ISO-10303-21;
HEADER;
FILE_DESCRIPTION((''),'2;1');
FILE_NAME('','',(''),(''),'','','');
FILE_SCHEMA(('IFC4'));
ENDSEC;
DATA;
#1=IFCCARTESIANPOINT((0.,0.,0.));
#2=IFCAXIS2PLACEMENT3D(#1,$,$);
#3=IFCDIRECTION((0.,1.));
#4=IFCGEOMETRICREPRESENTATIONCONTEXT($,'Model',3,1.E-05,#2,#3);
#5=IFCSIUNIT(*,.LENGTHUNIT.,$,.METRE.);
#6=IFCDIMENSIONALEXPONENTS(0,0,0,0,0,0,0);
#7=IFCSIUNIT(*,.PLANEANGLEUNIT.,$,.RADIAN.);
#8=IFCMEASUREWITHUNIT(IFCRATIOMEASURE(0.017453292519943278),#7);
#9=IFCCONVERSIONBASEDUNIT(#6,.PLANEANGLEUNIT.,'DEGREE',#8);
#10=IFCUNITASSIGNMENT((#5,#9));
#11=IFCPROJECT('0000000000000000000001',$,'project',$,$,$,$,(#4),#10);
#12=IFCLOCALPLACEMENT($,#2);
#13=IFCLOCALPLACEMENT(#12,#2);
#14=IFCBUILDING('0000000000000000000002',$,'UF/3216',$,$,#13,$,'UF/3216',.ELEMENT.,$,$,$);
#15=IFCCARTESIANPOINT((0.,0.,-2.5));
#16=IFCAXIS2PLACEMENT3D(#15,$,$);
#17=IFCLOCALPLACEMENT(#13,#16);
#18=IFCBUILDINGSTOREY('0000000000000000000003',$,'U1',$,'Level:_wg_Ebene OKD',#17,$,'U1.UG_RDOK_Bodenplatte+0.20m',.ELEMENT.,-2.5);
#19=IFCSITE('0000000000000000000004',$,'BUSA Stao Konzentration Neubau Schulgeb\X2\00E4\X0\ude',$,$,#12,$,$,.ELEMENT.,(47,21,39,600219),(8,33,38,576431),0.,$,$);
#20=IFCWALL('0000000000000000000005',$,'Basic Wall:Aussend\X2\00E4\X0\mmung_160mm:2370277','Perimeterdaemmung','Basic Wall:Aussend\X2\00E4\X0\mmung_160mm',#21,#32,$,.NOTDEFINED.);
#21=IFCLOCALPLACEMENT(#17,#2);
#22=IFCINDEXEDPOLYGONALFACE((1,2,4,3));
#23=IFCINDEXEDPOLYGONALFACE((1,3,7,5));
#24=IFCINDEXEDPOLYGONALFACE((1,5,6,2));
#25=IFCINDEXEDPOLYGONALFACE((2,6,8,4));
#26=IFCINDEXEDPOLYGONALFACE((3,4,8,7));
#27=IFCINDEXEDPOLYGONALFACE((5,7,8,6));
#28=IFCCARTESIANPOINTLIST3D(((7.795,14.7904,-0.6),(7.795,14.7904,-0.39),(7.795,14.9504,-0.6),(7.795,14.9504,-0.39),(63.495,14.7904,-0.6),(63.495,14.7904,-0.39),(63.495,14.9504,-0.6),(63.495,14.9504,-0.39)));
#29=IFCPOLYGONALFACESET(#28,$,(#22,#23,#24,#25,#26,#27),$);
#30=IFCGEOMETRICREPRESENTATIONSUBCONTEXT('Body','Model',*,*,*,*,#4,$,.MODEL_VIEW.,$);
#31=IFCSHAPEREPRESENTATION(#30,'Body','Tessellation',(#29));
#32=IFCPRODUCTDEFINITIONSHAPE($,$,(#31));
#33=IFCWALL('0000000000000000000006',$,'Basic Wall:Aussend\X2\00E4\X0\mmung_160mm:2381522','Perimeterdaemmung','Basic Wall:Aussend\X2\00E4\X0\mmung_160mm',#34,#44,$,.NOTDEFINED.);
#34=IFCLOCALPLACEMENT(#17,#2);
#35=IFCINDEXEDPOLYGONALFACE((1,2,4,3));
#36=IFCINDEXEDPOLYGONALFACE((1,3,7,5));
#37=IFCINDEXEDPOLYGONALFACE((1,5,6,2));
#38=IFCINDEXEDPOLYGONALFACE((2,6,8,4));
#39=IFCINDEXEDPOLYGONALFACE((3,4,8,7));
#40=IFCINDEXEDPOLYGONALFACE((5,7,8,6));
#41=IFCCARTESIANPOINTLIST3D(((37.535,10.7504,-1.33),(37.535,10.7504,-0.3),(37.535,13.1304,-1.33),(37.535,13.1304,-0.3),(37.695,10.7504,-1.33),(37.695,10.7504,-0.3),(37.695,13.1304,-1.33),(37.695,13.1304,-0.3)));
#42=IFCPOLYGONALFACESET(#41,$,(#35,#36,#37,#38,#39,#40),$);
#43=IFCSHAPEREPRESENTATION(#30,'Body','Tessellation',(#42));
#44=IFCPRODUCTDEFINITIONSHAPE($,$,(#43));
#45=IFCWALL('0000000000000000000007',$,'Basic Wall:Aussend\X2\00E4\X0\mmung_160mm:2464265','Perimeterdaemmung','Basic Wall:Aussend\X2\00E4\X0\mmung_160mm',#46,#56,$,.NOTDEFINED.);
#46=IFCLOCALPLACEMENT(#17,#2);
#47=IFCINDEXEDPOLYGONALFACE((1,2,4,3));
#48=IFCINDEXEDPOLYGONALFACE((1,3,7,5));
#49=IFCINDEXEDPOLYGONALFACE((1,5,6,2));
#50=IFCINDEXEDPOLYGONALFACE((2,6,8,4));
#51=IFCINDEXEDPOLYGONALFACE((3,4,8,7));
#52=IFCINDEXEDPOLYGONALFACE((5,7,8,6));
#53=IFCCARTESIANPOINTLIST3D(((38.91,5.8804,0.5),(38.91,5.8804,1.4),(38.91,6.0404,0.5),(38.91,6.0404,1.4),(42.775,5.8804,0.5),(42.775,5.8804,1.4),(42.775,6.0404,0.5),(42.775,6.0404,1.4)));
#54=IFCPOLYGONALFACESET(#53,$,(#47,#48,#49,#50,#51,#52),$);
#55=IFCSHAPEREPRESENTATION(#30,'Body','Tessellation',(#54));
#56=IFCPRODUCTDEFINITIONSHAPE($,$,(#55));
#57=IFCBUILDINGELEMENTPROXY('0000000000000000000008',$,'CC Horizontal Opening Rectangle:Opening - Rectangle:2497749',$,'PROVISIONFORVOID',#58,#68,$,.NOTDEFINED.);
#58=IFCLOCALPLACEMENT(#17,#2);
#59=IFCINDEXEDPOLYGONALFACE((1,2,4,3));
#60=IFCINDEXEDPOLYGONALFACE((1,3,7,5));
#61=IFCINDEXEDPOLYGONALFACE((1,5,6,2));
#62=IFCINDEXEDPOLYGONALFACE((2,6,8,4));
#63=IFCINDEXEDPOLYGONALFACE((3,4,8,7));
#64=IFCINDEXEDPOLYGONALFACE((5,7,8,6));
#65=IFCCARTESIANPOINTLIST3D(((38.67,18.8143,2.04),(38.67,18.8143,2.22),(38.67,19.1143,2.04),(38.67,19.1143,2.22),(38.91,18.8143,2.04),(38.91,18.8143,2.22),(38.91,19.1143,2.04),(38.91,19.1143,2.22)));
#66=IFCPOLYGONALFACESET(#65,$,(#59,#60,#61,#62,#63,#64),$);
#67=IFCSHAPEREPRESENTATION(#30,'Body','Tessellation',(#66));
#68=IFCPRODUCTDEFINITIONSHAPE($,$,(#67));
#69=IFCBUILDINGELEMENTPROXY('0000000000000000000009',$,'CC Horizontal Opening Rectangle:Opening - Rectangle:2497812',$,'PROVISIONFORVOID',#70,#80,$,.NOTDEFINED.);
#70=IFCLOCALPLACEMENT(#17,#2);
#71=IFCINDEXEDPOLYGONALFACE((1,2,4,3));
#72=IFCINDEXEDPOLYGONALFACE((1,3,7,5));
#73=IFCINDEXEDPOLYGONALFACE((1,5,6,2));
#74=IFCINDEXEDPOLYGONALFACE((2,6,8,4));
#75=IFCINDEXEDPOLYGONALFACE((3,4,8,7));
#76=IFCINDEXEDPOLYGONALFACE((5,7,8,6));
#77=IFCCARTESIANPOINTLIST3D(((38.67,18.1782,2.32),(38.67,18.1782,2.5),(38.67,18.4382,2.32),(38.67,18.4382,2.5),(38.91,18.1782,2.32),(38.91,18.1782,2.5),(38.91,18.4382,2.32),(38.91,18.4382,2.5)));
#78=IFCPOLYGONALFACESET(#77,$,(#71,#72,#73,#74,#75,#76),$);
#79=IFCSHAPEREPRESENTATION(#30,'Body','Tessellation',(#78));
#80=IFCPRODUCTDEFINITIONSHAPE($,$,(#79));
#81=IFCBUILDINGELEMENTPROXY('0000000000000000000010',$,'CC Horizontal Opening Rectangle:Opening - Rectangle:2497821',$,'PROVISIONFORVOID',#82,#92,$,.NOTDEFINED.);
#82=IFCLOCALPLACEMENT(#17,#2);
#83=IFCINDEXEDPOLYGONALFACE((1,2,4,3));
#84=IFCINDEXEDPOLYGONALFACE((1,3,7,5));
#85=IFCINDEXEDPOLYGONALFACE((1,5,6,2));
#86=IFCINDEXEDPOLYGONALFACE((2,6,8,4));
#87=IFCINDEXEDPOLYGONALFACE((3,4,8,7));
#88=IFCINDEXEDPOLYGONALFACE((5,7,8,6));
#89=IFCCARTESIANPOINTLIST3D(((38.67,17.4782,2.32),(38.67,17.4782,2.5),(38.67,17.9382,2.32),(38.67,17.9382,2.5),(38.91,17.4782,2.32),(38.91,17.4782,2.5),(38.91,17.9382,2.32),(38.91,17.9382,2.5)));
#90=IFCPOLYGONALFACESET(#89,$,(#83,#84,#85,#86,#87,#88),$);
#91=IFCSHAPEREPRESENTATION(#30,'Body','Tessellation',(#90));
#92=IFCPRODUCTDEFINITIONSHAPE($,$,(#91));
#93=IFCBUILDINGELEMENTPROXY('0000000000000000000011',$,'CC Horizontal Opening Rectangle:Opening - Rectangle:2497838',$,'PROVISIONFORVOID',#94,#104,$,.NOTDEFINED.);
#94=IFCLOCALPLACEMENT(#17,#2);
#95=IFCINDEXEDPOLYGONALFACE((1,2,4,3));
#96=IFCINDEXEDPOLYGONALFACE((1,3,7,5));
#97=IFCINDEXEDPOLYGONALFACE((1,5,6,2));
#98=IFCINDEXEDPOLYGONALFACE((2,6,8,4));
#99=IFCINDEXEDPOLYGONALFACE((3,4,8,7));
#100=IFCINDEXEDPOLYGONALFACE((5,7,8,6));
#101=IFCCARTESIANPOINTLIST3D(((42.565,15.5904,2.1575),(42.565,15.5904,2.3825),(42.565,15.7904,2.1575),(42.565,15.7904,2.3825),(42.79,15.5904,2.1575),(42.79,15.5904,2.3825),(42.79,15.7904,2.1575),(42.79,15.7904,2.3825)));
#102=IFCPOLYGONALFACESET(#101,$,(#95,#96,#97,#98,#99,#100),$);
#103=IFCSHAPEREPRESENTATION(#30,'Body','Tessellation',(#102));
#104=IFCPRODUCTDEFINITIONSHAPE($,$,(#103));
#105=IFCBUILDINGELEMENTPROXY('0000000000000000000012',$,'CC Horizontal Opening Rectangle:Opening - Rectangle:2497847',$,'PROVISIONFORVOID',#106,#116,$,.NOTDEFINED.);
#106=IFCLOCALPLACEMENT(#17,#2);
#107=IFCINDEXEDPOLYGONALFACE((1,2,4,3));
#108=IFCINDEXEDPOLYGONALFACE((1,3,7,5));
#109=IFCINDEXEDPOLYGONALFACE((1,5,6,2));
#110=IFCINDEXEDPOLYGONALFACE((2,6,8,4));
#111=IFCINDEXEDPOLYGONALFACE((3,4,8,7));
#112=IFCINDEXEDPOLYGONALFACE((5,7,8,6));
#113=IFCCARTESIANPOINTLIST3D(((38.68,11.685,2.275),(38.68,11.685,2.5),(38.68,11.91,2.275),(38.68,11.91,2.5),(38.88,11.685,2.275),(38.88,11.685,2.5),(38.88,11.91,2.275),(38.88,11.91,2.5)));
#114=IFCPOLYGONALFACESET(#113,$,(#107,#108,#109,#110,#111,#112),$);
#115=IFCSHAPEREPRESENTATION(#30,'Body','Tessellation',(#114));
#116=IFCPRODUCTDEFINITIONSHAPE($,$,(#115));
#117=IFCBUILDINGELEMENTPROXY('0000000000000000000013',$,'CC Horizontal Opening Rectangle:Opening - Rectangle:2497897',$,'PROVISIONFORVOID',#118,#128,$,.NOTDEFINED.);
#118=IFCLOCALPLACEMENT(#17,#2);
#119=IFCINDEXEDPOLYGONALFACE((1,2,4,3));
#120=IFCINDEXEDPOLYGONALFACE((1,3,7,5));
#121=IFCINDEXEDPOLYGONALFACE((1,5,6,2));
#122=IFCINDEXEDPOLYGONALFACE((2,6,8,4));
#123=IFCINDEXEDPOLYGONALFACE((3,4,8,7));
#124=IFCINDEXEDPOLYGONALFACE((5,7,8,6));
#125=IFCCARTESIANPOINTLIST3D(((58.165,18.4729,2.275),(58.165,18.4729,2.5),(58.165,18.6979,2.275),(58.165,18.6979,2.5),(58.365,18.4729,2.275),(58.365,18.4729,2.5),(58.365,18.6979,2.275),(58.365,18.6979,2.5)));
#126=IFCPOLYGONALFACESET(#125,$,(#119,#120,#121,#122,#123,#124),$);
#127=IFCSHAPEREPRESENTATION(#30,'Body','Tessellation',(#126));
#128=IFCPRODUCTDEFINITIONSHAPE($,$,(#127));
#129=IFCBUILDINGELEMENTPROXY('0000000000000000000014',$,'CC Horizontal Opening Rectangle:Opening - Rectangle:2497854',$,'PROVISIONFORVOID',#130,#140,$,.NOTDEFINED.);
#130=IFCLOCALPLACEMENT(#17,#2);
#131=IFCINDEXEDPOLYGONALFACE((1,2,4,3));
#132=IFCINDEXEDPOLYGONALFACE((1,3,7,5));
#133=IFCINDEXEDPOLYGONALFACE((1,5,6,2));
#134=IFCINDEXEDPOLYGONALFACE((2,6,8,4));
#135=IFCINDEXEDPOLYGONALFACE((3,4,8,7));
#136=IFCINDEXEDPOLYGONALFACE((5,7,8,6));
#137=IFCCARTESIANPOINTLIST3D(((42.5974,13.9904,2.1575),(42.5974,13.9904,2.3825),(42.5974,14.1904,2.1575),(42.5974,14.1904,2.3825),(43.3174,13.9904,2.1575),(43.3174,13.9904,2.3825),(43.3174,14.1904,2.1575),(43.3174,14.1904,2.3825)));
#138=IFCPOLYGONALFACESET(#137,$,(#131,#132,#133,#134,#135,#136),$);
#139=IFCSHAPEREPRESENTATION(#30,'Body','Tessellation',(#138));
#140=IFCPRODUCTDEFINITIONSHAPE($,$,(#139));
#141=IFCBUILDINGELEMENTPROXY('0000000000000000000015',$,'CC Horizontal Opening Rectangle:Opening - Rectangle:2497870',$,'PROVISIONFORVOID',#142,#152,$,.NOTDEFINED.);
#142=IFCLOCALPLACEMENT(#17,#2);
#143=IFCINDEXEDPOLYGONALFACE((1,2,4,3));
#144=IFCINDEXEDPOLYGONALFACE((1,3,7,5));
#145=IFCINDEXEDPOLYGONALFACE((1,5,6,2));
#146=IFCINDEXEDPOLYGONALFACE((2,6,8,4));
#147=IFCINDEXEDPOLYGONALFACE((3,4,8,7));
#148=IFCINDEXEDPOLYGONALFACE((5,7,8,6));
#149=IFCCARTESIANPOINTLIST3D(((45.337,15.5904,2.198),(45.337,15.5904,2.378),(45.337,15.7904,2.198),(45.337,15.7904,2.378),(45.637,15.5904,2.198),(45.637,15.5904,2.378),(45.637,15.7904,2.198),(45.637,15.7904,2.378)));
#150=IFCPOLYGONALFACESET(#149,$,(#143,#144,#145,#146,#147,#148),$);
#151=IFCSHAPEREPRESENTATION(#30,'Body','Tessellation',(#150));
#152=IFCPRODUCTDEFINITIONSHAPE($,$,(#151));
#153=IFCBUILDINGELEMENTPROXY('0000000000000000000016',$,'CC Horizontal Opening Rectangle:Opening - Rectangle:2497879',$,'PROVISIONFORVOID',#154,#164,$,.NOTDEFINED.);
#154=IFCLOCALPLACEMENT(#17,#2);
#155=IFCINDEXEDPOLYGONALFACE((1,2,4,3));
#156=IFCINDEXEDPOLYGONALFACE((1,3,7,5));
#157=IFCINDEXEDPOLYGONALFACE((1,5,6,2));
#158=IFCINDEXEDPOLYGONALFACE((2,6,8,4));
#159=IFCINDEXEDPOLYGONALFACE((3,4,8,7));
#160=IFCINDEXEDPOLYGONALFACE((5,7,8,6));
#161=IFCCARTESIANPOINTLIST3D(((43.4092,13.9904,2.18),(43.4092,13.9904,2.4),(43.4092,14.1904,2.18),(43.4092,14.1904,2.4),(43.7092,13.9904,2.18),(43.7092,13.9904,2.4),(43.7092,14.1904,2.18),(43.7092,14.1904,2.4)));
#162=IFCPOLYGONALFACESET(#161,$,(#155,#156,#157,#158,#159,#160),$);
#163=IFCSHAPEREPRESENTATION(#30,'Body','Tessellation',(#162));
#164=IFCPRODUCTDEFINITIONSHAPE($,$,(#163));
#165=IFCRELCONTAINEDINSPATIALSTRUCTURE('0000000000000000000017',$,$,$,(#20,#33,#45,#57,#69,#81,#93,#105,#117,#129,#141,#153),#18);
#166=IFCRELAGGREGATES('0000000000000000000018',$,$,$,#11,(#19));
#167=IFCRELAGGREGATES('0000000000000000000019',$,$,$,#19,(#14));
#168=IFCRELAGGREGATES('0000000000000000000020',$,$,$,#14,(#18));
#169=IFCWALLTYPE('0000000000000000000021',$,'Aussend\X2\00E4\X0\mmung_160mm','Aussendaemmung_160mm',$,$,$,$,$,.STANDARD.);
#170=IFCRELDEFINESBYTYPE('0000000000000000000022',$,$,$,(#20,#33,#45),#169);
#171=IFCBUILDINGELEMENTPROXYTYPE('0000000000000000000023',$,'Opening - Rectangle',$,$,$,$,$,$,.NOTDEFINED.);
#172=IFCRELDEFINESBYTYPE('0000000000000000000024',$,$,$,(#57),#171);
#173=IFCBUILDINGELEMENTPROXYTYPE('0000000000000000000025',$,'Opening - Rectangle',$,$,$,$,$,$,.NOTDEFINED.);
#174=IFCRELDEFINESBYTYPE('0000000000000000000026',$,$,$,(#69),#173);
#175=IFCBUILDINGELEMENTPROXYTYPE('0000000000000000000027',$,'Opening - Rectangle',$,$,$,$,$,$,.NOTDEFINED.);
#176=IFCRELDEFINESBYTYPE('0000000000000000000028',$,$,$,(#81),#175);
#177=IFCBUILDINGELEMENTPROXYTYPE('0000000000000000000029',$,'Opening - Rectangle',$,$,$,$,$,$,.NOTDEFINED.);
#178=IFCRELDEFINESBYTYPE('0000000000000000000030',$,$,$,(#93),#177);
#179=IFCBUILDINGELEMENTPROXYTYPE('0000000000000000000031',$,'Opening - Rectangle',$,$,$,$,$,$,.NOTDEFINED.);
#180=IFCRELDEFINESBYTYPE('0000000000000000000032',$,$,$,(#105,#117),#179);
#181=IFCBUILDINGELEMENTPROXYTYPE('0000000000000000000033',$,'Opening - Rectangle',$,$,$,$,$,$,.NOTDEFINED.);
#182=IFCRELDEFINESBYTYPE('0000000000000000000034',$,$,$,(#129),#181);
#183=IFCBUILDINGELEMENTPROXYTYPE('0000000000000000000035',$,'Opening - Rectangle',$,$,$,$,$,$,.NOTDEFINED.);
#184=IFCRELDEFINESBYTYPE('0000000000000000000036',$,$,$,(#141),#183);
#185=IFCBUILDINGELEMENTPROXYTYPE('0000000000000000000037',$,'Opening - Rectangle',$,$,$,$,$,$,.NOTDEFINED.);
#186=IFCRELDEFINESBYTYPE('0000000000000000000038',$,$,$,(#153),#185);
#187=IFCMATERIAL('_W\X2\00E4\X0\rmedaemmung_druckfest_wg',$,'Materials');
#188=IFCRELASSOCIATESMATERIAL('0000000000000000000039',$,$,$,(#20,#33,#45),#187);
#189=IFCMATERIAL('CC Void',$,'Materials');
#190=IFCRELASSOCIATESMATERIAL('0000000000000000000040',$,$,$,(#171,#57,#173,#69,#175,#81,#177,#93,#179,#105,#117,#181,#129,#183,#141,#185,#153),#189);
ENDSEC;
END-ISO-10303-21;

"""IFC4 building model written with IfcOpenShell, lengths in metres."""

from ifc_helpers import new_model, entity, si_unit, converted_unit, direction, frame, origin, place, context, subcontext, project, spatial, indexed_curve, outline, extrude, source, transform, mapped, material, type_object, type_shapes, element, save


model = new_model("IFC4")

# Units and contexts
model_context = context("Model", 3, precision=1e-05, world=origin(), true_north=direction((0.0, 1.0)))
body_context = subcontext(model_context, "Body", "Model", "MODEL_VIEW")
ifc_project = project(units=[si_unit("LENGTHUNIT", "METRE"), converted_unit("PLANEANGLEUNIT", "DEGREE", entity("IfcRatioMeasure", 0.017453292519943278), si_unit("PLANEANGLEUNIT", "RADIAN"), dimensions=[0, 0, 0, 0, 0, 0, 0])], contexts=[model_context])

# Site, building, storey
site_placement = place(None, origin())
site = spatial("IfcSite", under=ifc_project, at=site_placement, Name="BUSA Stao Konzentration Neubau Schulgebäude", CompositionType="ELEMENT", RefLatitude=(47, 21, 39, 600219), RefLongitude=(8, 33, 38, 576431), RefElevation=0.0)
building_placement = place(site_placement, origin())
building = spatial("IfcBuilding", under=site, at=building_placement, Name="UF/3216", LongName="UF/3216", CompositionType="ELEMENT")
storey_placement = place(building_placement, frame((0.0, 0.0, -2.5)))
storey = spatial("IfcBuildingStorey", under=building, at=storey_placement, Name="U1", ObjectType="Level:_wg_Ebene OKD", LongName="U1.UG_RDOK_Bodenplatte+0.20m", CompositionType="ELEMENT", Elevation=-2.5)

# Shared definitions
ifc_material_1 = material(Name="_Wärmedaemmung_druckfest_wg", Category="Materials")
wall_type_1 = type_object("IfcWallType", Name="Aussendämmung_160mm", Description="Aussendaemmung_160mm", PredefinedType="STANDARD")

# Walls
wall_1_placement = place(storey_placement, frame((63.495, 14.8704, -0.6), z_axis=(0.0, 0.0, 1.0), x_axis=(-1.0, 0.0, 0.0)))
element("IfcWall", 1, at=wall_1_placement, inside=storey, type_object=wall_type_1, material=ifc_material_1, Name="Basic Wall:Aussendämmung_160mm:2370277", Description="Perimeterdaemmung", ObjectType="Basic Wall:Aussendämmung_160mm", PredefinedType="NOTDEFINED", context=body_context, shape_type="SweptSolid", body=[
    extrude(outline(indexed_curve([(55.7, 0.08), (0.0, 0.08), (0.0, -0.08), (55.7, -0.08), (55.7, 0.08)], self_intersect=False)), origin(), (0.0, 0.0, 1.0), 0.21),
])
wall_2_placement = place(storey_placement, frame((37.615, 13.1304, -1.33), z_axis=(0.0, 0.0, 1.0), x_axis=(0.0, -1.0, 0.0)))
element("IfcWall", 2, at=wall_2_placement, inside=storey, type_object=wall_type_1, material=ifc_material_1, Name="Basic Wall:Aussendämmung_160mm:2381522", Description="Perimeterdaemmung", ObjectType="Basic Wall:Aussendämmung_160mm", PredefinedType="NOTDEFINED", context=body_context, shape_type="SweptSolid", body=[
    extrude(outline(indexed_curve([(2.38, 0.08), (0.0, 0.08), (0.0, -0.08), (2.38, -0.08), (2.38, 0.08)], self_intersect=False)), origin(), (0.0, 0.0, 1.0), 1.03),
])
wall_3_placement = place(storey_placement, frame((42.775, 5.9604, 0.5), z_axis=(0.0, 0.0, 1.0), x_axis=(-1.0, 0.0, 0.0)))
element("IfcWall", 3, at=wall_3_placement, inside=storey, type_object=wall_type_1, material=ifc_material_1, Name="Basic Wall:Aussendämmung_160mm:2464265", Description="Perimeterdaemmung", ObjectType="Basic Wall:Aussendämmung_160mm", PredefinedType="NOTDEFINED", context=body_context, shape_type="SweptSolid", body=[
    extrude(outline(indexed_curve([(3.865, 0.08), (0.0, 0.08), (0.0, -0.08), (3.865, -0.08), (3.865, 0.08)], self_intersect=False)), origin(), (0.0, 0.0, 1.0), 0.9),
])

# Building element proxies
ifc_material_2 = material(Name="CC Void", Category="Materials")
building_element_proxy_type_1 = type_object("IfcBuildingElementProxyType", Name="Opening - Rectangle", PredefinedType="NOTDEFINED", material=ifc_material_2)
shared_shape_1 = source(origin(), body_context, "Body", "SweptSolid", [
    extrude(outline(indexed_curve([(-0.12, -0.15), (0.12, -0.15), (0.12, 0.15), (-0.12, 0.15), (-0.12, -0.15)], self_intersect=False)), frame((0.0, 0.0, -0.46), z_axis=(0.0, 0.0, 1.0), x_axis=(0.0, -1.0, 0.0)), (0.0, 0.0, 1.0), 0.18),
])
type_shapes(building_element_proxy_type_1, [shared_shape_1])
proxy_1_placement = place(storey_placement, frame((38.79, 18.9643, 2.5), z_axis=(0.0, 0.0, 1.0), x_axis=(0.0, 1.0, 0.0)))
element("IfcBuildingElementProxy", 4, at=proxy_1_placement, inside=storey, type_object=building_element_proxy_type_1, material=ifc_material_2, Name="CC Horizontal Opening Rectangle:Opening - Rectangle:2497749", ObjectType="PROVISIONFORVOID", PredefinedType="NOTDEFINED", context=body_context, shape_type="MappedRepresentation", body=[
    mapped(shared_shape_1, transform((0.0, 0.0, 0.0), scale=1.0)),
])
building_element_proxy_type_2 = type_object("IfcBuildingElementProxyType", Name="Opening - Rectangle", PredefinedType="NOTDEFINED", material=ifc_material_2)
shared_shape_2 = source(origin(), body_context, "Body", "SweptSolid", [
    extrude(outline(indexed_curve([(-0.12, -0.13), (0.12, -0.13), (0.12, 0.13), (-0.12, 0.13), (-0.12, -0.13)], self_intersect=False)), frame((0.0, 0.0, -0.18), z_axis=(0.0, 0.0, 1.0), x_axis=(0.0, -1.0, 0.0)), (0.0, 0.0, 1.0), 0.18),
])
type_shapes(building_element_proxy_type_2, [shared_shape_2])
proxy_2_placement = place(storey_placement, frame((38.79, 18.3082, 2.5), z_axis=(0.0, 0.0, 1.0), x_axis=(0.0, 1.0, 0.0)))
element("IfcBuildingElementProxy", 5, at=proxy_2_placement, inside=storey, type_object=building_element_proxy_type_2, material=ifc_material_2, Name="CC Horizontal Opening Rectangle:Opening - Rectangle:2497812", ObjectType="PROVISIONFORVOID", PredefinedType="NOTDEFINED", context=body_context, shape_type="MappedRepresentation", body=[
    mapped(shared_shape_2, transform((0.0, 0.0, 0.0), scale=1.0)),
])
building_element_proxy_type_3 = type_object("IfcBuildingElementProxyType", Name="Opening - Rectangle", PredefinedType="NOTDEFINED", material=ifc_material_2)
shared_shape_3 = source(origin(), body_context, "Body", "SweptSolid", [
    extrude(outline(indexed_curve([(-0.12, -0.23), (0.12, -0.23), (0.12, 0.23), (-0.12, 0.23), (-0.12, -0.23)], self_intersect=False)), frame((0.0, 0.0, -0.18), z_axis=(0.0, 0.0, 1.0), x_axis=(0.0, -1.0, 0.0)), (0.0, 0.0, 1.0), 0.18),
])
type_shapes(building_element_proxy_type_3, [shared_shape_3])
proxy_3_placement = place(storey_placement, frame((38.79, 17.7082, 2.5), z_axis=(0.0, 0.0, 1.0), x_axis=(0.0, 1.0, 0.0)))
element("IfcBuildingElementProxy", 6, at=proxy_3_placement, inside=storey, type_object=building_element_proxy_type_3, material=ifc_material_2, Name="CC Horizontal Opening Rectangle:Opening - Rectangle:2497821", ObjectType="PROVISIONFORVOID", PredefinedType="NOTDEFINED", context=body_context, shape_type="MappedRepresentation", body=[
    mapped(shared_shape_3, transform((0.0, 0.0, 0.0), scale=1.0)),
])
building_element_proxy_type_4 = type_object("IfcBuildingElementProxyType", Name="Opening - Rectangle", PredefinedType="NOTDEFINED", material=ifc_material_2)
shared_shape_4 = source(origin(), body_context, "Body", "SweptSolid", [
    extrude(outline(indexed_curve([(-0.1, -0.1125), (0.1, -0.1125), (0.1, 0.1125), (-0.1, 0.1125), (-0.1, -0.1125)], self_intersect=False)), frame((0.0, 0.0, -0.3425), z_axis=(0.0, 0.0, 1.0), x_axis=(0.0, -1.0, 0.0)), (0.0, 0.0, 1.0), 0.225),
])
type_shapes(building_element_proxy_type_4, [shared_shape_4])
proxy_4_placement = place(storey_placement, frame((42.6775, 15.6904, 2.5)))
element("IfcBuildingElementProxy", 7, at=proxy_4_placement, inside=storey, type_object=building_element_proxy_type_4, material=ifc_material_2, Name="CC Horizontal Opening Rectangle:Opening - Rectangle:2497838", ObjectType="PROVISIONFORVOID", PredefinedType="NOTDEFINED", context=body_context, shape_type="MappedRepresentation", body=[
    mapped(shared_shape_4, transform((0.0, 0.0, 0.0), scale=1.0)),
])
building_element_proxy_type_5 = type_object("IfcBuildingElementProxyType", Name="Opening - Rectangle", PredefinedType="NOTDEFINED", material=ifc_material_2)
shared_shape_5 = source(origin(), body_context, "Body", "SweptSolid", [
    extrude(outline(indexed_curve([(-0.1, -0.1125), (0.1, -0.1125), (0.1, 0.1125), (-0.1, 0.1125), (-0.1, -0.1125)], self_intersect=False)), frame((0.0, 0.0, -0.225), z_axis=(0.0, 0.0, 1.0), x_axis=(0.0, -1.0, 0.0)), (0.0, 0.0, 1.0), 0.225),
])
type_shapes(building_element_proxy_type_5, [shared_shape_5])
for number, where, z_axis, x_axis, name in (
    (8, (38.78, 11.7975, 2.5), (0.0, 0.0, 1.0), (0.0, 1.0, 0.0), "CC Horizontal Opening Rectangle:Opening - Rectangle:2497847"),
    (9, (58.265, 18.5854, 2.5), (0.0, 0.0, 1.0), (0.0, 1.0, 0.0), "CC Horizontal Opening Rectangle:Opening - Rectangle:2497897"),
):
    element("IfcBuildingElementProxy", number, at=place(storey_placement, frame(where, z_axis=z_axis, x_axis=x_axis)), inside=storey, type_object=building_element_proxy_type_5, material=ifc_material_2, Name=name, ObjectType="PROVISIONFORVOID", PredefinedType="NOTDEFINED", context=body_context, shape_type="MappedRepresentation", body=[
        mapped(shared_shape_5, transform((0.0, 0.0, 0.0), scale=1.0)),
    ])
building_element_proxy_type_6 = type_object("IfcBuildingElementProxyType", Name="Opening - Rectangle", PredefinedType="NOTDEFINED", material=ifc_material_2)
shared_shape_6 = source(origin(), body_context, "Body", "SweptSolid", [
    extrude(outline(indexed_curve([(-0.1, -0.36), (0.1, -0.36), (0.1, 0.36), (-0.1, 0.36), (-0.1, -0.36)], self_intersect=False)), frame((0.0, 0.0, -0.3425), z_axis=(0.0, 0.0, 1.0), x_axis=(0.0, -1.0, 0.0)), (0.0, 0.0, 1.0), 0.225),
])
type_shapes(building_element_proxy_type_6, [shared_shape_6])
proxy_5_placement = place(storey_placement, frame((42.9574, 14.0904, 2.5)))
element("IfcBuildingElementProxy", 10, at=proxy_5_placement, inside=storey, type_object=building_element_proxy_type_6, material=ifc_material_2, Name="CC Horizontal Opening Rectangle:Opening - Rectangle:2497854", ObjectType="PROVISIONFORVOID", PredefinedType="NOTDEFINED", context=body_context, shape_type="MappedRepresentation", body=[
    mapped(shared_shape_6, transform((0.0, 0.0, 0.0), scale=1.0)),
])
building_element_proxy_type_7 = type_object("IfcBuildingElementProxyType", Name="Opening - Rectangle", PredefinedType="NOTDEFINED", material=ifc_material_2)
shared_shape_7 = source(origin(), body_context, "Body", "SweptSolid", [
    extrude(outline(indexed_curve([(-0.1, -0.15), (0.1, -0.15), (0.1, 0.15), (-0.1, 0.15), (-0.1, -0.15)], self_intersect=False)), frame((0.0, 0.0, -0.302), z_axis=(0.0, 0.0, 1.0), x_axis=(0.0, -1.0, 0.0)), (0.0, 0.0, 1.0), 0.18),
])
type_shapes(building_element_proxy_type_7, [shared_shape_7])
proxy_6_placement = place(storey_placement, frame((45.487, 15.6904, 2.5)))
element("IfcBuildingElementProxy", 11, at=proxy_6_placement, inside=storey, type_object=building_element_proxy_type_7, material=ifc_material_2, Name="CC Horizontal Opening Rectangle:Opening - Rectangle:2497870", ObjectType="PROVISIONFORVOID", PredefinedType="NOTDEFINED", context=body_context, shape_type="MappedRepresentation", body=[
    mapped(shared_shape_7, transform((0.0, 0.0, 0.0), scale=1.0)),
])
building_element_proxy_type_8 = type_object("IfcBuildingElementProxyType", Name="Opening - Rectangle", PredefinedType="NOTDEFINED", material=ifc_material_2)
shared_shape_8 = source(origin(), body_context, "Body", "SweptSolid", [
    extrude(outline(indexed_curve([(-0.1, -0.15), (0.1, -0.15), (0.1, 0.15), (-0.1, 0.15), (-0.1, -0.15)], self_intersect=False)), frame((0.0, 0.0, -0.32), z_axis=(0.0, 0.0, 1.0), x_axis=(0.0, -1.0, 0.0)), (0.0, 0.0, 1.0), 0.22),
])
type_shapes(building_element_proxy_type_8, [shared_shape_8])
proxy_7_placement = place(storey_placement, frame((43.5592, 14.0904, 2.5)))
element("IfcBuildingElementProxy", 12, at=proxy_7_placement, inside=storey, type_object=building_element_proxy_type_8, material=ifc_material_2, Name="CC Horizontal Opening Rectangle:Opening - Rectangle:2497879", ObjectType="PROVISIONFORVOID", PredefinedType="NOTDEFINED", context=body_context, shape_type="MappedRepresentation", body=[
    mapped(shared_shape_8, transform((0.0, 0.0, 0.0), scale=1.0)),
])

save(model, "model.ifc")
